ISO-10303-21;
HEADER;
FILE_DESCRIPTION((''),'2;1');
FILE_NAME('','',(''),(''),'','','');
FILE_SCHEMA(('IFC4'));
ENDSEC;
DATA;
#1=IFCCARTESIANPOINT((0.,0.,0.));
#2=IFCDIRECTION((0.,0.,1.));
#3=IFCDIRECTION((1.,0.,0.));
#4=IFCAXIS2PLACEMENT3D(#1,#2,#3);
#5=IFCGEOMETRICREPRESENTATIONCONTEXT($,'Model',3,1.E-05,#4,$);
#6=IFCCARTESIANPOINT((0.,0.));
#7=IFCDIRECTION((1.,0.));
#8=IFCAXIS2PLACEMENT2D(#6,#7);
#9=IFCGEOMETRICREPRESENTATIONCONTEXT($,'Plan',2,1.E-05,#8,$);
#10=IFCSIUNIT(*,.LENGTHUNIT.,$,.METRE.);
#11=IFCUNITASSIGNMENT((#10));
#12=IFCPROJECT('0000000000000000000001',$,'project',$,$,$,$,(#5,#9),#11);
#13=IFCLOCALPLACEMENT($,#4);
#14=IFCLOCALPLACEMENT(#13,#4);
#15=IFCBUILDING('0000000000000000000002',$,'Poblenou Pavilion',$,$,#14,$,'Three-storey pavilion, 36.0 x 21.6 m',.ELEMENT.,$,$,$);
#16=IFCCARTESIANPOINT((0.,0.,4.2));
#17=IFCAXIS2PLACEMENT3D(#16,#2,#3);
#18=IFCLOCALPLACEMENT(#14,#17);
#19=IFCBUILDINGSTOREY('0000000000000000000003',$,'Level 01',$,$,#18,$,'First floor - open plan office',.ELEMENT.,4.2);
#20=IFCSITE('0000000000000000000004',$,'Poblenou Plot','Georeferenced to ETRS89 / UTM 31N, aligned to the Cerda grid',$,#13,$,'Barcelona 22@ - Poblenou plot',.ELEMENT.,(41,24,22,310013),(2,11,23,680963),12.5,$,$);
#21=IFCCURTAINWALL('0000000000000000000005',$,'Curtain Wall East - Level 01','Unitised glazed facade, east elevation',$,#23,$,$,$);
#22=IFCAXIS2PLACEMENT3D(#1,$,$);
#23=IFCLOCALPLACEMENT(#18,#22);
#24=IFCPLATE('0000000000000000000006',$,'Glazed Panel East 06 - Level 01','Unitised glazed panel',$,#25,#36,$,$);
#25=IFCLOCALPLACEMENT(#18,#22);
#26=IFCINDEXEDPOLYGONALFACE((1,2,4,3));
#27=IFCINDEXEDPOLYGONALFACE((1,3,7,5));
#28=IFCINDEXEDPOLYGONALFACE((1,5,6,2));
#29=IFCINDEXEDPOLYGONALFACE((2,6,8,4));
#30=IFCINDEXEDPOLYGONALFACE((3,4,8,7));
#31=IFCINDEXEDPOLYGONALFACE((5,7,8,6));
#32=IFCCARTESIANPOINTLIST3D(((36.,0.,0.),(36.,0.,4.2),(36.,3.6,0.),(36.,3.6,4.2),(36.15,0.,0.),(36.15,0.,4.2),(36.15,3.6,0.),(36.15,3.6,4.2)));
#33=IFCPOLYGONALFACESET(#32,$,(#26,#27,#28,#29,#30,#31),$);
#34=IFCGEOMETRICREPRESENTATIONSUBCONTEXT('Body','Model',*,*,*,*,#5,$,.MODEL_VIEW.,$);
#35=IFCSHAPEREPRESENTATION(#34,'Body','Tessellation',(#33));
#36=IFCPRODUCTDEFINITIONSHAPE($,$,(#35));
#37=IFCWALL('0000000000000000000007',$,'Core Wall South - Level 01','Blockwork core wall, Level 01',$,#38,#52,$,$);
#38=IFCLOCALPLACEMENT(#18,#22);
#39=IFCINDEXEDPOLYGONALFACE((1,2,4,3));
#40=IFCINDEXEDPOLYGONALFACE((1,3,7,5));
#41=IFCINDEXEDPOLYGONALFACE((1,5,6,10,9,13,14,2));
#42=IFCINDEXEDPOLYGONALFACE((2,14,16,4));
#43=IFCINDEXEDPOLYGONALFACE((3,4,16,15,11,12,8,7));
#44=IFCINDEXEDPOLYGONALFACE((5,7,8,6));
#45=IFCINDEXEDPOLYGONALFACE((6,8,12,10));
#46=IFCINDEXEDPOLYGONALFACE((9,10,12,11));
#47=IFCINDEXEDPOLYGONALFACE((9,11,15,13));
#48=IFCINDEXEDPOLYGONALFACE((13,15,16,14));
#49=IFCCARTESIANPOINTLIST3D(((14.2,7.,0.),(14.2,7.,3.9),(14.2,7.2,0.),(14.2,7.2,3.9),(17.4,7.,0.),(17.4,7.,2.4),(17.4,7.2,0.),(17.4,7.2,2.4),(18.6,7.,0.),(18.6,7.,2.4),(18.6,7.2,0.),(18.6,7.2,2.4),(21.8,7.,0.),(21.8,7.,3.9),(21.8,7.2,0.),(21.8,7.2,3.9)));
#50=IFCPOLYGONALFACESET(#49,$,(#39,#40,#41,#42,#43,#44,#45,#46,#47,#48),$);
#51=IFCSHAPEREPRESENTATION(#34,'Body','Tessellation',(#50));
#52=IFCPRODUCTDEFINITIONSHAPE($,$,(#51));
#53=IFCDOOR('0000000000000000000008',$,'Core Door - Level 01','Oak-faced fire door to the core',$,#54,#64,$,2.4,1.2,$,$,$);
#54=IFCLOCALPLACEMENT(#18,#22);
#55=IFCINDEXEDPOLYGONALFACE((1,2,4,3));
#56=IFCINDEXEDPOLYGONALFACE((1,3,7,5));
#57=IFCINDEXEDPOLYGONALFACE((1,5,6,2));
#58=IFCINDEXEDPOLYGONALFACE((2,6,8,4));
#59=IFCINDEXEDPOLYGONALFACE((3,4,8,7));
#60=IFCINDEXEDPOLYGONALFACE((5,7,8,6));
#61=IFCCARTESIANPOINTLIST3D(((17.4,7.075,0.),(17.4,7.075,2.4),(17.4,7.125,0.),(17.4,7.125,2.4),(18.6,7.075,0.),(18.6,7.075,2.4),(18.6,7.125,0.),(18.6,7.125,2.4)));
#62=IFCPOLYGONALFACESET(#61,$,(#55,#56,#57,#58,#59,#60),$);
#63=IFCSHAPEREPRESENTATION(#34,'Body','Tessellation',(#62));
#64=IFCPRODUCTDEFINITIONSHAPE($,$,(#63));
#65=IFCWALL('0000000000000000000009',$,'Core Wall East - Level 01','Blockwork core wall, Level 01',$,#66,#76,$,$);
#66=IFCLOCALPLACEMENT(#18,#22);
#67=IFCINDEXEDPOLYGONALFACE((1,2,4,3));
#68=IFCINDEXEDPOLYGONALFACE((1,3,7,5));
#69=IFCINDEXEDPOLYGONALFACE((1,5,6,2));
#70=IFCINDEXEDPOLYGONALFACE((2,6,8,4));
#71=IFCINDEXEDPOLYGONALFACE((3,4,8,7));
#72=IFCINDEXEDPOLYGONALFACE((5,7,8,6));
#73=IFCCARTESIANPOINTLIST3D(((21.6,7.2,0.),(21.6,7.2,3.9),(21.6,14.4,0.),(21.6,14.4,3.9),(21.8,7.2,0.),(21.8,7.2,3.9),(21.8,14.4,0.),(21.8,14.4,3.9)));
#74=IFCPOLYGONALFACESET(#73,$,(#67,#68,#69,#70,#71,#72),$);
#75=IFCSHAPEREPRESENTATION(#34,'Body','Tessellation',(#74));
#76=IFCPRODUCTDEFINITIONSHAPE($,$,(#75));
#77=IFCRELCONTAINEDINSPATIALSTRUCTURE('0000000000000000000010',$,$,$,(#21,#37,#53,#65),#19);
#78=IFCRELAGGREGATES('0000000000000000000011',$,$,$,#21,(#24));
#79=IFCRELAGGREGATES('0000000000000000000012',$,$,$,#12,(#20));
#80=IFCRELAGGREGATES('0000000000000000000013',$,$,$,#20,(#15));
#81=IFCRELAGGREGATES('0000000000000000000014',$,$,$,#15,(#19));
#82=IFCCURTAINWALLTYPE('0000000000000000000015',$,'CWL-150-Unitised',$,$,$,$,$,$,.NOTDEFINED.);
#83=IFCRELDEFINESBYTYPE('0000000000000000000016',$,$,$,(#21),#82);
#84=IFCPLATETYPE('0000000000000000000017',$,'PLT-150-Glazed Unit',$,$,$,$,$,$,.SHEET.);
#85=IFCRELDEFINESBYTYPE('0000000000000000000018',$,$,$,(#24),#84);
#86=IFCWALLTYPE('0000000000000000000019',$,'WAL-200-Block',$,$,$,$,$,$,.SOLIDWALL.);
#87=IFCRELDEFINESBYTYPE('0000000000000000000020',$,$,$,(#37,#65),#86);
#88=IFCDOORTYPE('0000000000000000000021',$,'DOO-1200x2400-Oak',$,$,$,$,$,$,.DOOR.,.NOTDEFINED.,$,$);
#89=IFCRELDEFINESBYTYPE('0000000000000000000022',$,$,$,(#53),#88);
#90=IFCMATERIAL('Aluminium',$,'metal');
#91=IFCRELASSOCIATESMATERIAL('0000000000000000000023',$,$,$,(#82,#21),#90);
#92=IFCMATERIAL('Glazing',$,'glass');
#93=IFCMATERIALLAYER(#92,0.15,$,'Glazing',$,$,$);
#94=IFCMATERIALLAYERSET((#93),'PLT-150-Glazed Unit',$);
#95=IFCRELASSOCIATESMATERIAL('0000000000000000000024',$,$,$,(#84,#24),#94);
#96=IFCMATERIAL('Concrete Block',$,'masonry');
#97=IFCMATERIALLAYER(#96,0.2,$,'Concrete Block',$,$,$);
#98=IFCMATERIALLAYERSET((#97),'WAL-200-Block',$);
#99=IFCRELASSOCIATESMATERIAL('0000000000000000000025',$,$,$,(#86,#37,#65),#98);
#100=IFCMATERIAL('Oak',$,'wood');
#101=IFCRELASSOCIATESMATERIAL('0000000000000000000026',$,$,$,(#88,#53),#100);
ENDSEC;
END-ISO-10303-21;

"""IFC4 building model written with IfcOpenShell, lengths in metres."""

from ifc_helpers import new_model, si_unit, frame, origin_with_axes, origin_2d_with_axis, place, context, subcontext, project, spatial, line, indexed_curve, outline, extrude, material, layer, layer_set, layer_usage, type_object, element, fill, aggregate, save


model = new_model("IFC4")

# Units and contexts
model_context = context("Model", 3, precision=1e-05, world=origin_with_axes())
plan_context = context("Plan", 2, precision=1e-05, world=origin_2d_with_axis())
body_context = subcontext(model_context, "Body", "Model", "MODEL_VIEW")
ifc_project = project(units=[si_unit("LENGTHUNIT", "METRE")], contexts=[model_context, plan_context])

# Site, building, storey
site_placement = place(None, origin_with_axes())
site = spatial("IfcSite", under=ifc_project, at=site_placement, Name="Poblenou Plot", Description="Georeferenced to ETRS89 / UTM 31N, aligned to the Cerda grid", LongName="Barcelona 22@ - Poblenou plot", CompositionType="ELEMENT", RefLatitude=(41, 24, 22, 310013), RefLongitude=(2, 11, 23, 680963), RefElevation=12.5)
building_placement = place(site_placement, origin_with_axes())
building = spatial("IfcBuilding", under=site, at=building_placement, Name="Poblenou Pavilion", LongName="Three-storey pavilion, 36.0 x 21.6 m", CompositionType="ELEMENT")
storey_placement = place(building_placement, frame((0.0, 0.0, 4.2), z_axis=(0.0, 0.0, 1.0), x_axis=(1.0, 0.0, 0.0)))
storey = spatial("IfcBuildingStorey", under=building, at=storey_placement, Name="Level 01", LongName="First floor - open plan office", CompositionType="ELEMENT", Elevation=4.2)

# Curtain wall, plate
ifc_material_1 = material(Name="Aluminium", Category="metal")
curtain_wall_type = type_object("IfcCurtainWallType", Name="CWL-150-Unitised", PredefinedType="NOTDEFINED", material=ifc_material_1)
ifc_material_2 = material(Name="Glazing", Category="glass")
ifc_layer_1 = layer(ifc_material_2, 0.15, Name="Glazing")
ifc_layer_set_1 = layer_set([ifc_layer_1], Name="PLT-150-Glazed Unit")
plate_type = type_object("IfcPlateType", Name="PLT-150-Glazed Unit", PredefinedType="SHEET", material=ifc_layer_set_1)
curtain_wall_1_placement = place(storey_placement, frame((36.0, 21.6, 0.0), z_axis=(0.0, 0.0, 1.0), x_axis=(0.0, -1.0, 0.0)))
curtain_wall_1 = element("IfcCurtainWall", 1, at=curtain_wall_1_placement, inside=storey, type_object=curtain_wall_type, material=ifc_material_1, Name="Curtain Wall East - Level 01", Description="Unitised glazed facade, east elevation")
ifc_layer_usage_1 = layer_usage(ifc_layer_set_1, "AXIS2", "POSITIVE", 0.0)
plate_1_placement = place(curtain_wall_1_placement, frame((18.0, 0.0, 0.0), z_axis=(0.0, 0.0, 1.0), x_axis=(1.0, 0.0, 0.0)))
plate_1 = element("IfcPlate", 2, at=plate_1_placement, type_object=plate_type, material=ifc_layer_usage_1, Name="Glazed Panel East 06 - Level 01", Description="Unitised glazed panel", context=body_context, shape_type="SweptSolid", body=[
    extrude(outline(indexed_curve([(0.0, 0.0), (3.6, 0.0), (3.6, 0.15), (0.0, 0.15)], segments=[line(1, 2, 3, 4, 1)])), origin_with_axes(), (0.0, 0.0, 1.0), 4.2),
])
aggregate(curtain_wall_1, [plate_1])

# Wall, opening, door
ifc_material_3 = material(Name="Concrete Block", Category="masonry")
ifc_layer_2 = layer(ifc_material_3, 0.2, Name="Concrete Block")
ifc_layer_set_2 = layer_set([ifc_layer_2], Name="WAL-200-Block")
ifc_layer_usage_2 = layer_usage(ifc_layer_set_2, "AXIS2", "POSITIVE", 0.0)
wall_type = type_object("IfcWallType", Name="WAL-200-Block", PredefinedType="SOLIDWALL", material=ifc_layer_set_2)
wall_1_placement = place(storey_placement, frame((21.8, 7.2, 0.0), z_axis=(0.0, 0.0, 1.0), x_axis=(-1.0, 0.0, 0.0)))
wall_1 = element("IfcWall", 3, at=wall_1_placement, inside=storey, type_object=wall_type, material=ifc_layer_usage_2, Name="Core Wall South - Level 01", Description="Blockwork core wall, Level 01", context=body_context, shape_type="SweptSolid", body=[
    extrude(outline(indexed_curve([(0.0, 0.0), (7.6, 0.0), (7.6, 0.2), (0.0, 0.2)], segments=[line(1, 2, 3, 4, 1)])), origin_with_axes(), (0.0, 0.0, 1.0), 3.9),
])
opening_placement = place(wall_1_placement, frame((4.4, 0.21, 0.0), z_axis=(0.0, 0.0, 1.0), x_axis=(-1.0, 0.0, 0.0)))
opening = element("IfcOpeningElement", 4, at=opening_placement, cuts=wall_1, PredefinedType="OPENING", context=body_context, shape_type="SweptSolid", body=[
    extrude(outline(indexed_curve([(0.0, 0.0), (1.2, 0.0), (1.2, 0.22), (0.0, 0.22)], segments=[line(1, 2, 3, 4, 1)])), origin_with_axes(), (0.0, 0.0, 1.0), 2.4),
])
ifc_material_4 = material(Name="Oak", Category="wood")
door_type = type_object("IfcDoorType", Name="DOO-1200x2400-Oak", OperationType="NOTDEFINED", PredefinedType="DOOR", material=ifc_material_4)
door_placement = place(storey_placement, frame((17.4, 7.075, 0.0), z_axis=(0.0, 0.0, 1.0), x_axis=(1.0, 0.0, 0.0)))
door = element("IfcDoor", 5, at=door_placement, inside=storey, type_object=door_type, material=ifc_material_4, Name="Core Door - Level 01", Description="Oak-faced fire door to the core", OverallHeight=2.4, OverallWidth=1.2, context=body_context, shape_type="SweptSolid", body=[
    extrude(outline(indexed_curve([(0.0, 0.0), (1.2, 0.0), (1.2, 0.05), (0.0, 0.05)], segments=[line(1, 2, 3, 4, 1)])), origin_with_axes(), (0.0, 0.0, 1.0), 2.4),
])
fill(opening, door)

# Wall
ifc_layer_usage_3 = layer_usage(ifc_layer_set_2, "AXIS2", "POSITIVE", 0.0)
wall_2_placement = place(storey_placement, frame((21.6, 14.4, 0.0), z_axis=(0.0, 0.0, 1.0), x_axis=(0.0, -1.0, 0.0)))
element("IfcWall", 6, at=wall_2_placement, inside=storey, type_object=wall_type, material=ifc_layer_usage_3, Name="Core Wall East - Level 01", Description="Blockwork core wall, Level 01", context=body_context, shape_type="SweptSolid", body=[
    extrude(outline(indexed_curve([(0.0, 0.0), (7.2, 0.0), (7.2, 0.2), (0.0, 0.2)], segments=[line(1, 2, 3, 4, 1)])), origin_with_axes(), (0.0, 0.0, 1.0), 3.9),
])

save(model, "model.ifc")
